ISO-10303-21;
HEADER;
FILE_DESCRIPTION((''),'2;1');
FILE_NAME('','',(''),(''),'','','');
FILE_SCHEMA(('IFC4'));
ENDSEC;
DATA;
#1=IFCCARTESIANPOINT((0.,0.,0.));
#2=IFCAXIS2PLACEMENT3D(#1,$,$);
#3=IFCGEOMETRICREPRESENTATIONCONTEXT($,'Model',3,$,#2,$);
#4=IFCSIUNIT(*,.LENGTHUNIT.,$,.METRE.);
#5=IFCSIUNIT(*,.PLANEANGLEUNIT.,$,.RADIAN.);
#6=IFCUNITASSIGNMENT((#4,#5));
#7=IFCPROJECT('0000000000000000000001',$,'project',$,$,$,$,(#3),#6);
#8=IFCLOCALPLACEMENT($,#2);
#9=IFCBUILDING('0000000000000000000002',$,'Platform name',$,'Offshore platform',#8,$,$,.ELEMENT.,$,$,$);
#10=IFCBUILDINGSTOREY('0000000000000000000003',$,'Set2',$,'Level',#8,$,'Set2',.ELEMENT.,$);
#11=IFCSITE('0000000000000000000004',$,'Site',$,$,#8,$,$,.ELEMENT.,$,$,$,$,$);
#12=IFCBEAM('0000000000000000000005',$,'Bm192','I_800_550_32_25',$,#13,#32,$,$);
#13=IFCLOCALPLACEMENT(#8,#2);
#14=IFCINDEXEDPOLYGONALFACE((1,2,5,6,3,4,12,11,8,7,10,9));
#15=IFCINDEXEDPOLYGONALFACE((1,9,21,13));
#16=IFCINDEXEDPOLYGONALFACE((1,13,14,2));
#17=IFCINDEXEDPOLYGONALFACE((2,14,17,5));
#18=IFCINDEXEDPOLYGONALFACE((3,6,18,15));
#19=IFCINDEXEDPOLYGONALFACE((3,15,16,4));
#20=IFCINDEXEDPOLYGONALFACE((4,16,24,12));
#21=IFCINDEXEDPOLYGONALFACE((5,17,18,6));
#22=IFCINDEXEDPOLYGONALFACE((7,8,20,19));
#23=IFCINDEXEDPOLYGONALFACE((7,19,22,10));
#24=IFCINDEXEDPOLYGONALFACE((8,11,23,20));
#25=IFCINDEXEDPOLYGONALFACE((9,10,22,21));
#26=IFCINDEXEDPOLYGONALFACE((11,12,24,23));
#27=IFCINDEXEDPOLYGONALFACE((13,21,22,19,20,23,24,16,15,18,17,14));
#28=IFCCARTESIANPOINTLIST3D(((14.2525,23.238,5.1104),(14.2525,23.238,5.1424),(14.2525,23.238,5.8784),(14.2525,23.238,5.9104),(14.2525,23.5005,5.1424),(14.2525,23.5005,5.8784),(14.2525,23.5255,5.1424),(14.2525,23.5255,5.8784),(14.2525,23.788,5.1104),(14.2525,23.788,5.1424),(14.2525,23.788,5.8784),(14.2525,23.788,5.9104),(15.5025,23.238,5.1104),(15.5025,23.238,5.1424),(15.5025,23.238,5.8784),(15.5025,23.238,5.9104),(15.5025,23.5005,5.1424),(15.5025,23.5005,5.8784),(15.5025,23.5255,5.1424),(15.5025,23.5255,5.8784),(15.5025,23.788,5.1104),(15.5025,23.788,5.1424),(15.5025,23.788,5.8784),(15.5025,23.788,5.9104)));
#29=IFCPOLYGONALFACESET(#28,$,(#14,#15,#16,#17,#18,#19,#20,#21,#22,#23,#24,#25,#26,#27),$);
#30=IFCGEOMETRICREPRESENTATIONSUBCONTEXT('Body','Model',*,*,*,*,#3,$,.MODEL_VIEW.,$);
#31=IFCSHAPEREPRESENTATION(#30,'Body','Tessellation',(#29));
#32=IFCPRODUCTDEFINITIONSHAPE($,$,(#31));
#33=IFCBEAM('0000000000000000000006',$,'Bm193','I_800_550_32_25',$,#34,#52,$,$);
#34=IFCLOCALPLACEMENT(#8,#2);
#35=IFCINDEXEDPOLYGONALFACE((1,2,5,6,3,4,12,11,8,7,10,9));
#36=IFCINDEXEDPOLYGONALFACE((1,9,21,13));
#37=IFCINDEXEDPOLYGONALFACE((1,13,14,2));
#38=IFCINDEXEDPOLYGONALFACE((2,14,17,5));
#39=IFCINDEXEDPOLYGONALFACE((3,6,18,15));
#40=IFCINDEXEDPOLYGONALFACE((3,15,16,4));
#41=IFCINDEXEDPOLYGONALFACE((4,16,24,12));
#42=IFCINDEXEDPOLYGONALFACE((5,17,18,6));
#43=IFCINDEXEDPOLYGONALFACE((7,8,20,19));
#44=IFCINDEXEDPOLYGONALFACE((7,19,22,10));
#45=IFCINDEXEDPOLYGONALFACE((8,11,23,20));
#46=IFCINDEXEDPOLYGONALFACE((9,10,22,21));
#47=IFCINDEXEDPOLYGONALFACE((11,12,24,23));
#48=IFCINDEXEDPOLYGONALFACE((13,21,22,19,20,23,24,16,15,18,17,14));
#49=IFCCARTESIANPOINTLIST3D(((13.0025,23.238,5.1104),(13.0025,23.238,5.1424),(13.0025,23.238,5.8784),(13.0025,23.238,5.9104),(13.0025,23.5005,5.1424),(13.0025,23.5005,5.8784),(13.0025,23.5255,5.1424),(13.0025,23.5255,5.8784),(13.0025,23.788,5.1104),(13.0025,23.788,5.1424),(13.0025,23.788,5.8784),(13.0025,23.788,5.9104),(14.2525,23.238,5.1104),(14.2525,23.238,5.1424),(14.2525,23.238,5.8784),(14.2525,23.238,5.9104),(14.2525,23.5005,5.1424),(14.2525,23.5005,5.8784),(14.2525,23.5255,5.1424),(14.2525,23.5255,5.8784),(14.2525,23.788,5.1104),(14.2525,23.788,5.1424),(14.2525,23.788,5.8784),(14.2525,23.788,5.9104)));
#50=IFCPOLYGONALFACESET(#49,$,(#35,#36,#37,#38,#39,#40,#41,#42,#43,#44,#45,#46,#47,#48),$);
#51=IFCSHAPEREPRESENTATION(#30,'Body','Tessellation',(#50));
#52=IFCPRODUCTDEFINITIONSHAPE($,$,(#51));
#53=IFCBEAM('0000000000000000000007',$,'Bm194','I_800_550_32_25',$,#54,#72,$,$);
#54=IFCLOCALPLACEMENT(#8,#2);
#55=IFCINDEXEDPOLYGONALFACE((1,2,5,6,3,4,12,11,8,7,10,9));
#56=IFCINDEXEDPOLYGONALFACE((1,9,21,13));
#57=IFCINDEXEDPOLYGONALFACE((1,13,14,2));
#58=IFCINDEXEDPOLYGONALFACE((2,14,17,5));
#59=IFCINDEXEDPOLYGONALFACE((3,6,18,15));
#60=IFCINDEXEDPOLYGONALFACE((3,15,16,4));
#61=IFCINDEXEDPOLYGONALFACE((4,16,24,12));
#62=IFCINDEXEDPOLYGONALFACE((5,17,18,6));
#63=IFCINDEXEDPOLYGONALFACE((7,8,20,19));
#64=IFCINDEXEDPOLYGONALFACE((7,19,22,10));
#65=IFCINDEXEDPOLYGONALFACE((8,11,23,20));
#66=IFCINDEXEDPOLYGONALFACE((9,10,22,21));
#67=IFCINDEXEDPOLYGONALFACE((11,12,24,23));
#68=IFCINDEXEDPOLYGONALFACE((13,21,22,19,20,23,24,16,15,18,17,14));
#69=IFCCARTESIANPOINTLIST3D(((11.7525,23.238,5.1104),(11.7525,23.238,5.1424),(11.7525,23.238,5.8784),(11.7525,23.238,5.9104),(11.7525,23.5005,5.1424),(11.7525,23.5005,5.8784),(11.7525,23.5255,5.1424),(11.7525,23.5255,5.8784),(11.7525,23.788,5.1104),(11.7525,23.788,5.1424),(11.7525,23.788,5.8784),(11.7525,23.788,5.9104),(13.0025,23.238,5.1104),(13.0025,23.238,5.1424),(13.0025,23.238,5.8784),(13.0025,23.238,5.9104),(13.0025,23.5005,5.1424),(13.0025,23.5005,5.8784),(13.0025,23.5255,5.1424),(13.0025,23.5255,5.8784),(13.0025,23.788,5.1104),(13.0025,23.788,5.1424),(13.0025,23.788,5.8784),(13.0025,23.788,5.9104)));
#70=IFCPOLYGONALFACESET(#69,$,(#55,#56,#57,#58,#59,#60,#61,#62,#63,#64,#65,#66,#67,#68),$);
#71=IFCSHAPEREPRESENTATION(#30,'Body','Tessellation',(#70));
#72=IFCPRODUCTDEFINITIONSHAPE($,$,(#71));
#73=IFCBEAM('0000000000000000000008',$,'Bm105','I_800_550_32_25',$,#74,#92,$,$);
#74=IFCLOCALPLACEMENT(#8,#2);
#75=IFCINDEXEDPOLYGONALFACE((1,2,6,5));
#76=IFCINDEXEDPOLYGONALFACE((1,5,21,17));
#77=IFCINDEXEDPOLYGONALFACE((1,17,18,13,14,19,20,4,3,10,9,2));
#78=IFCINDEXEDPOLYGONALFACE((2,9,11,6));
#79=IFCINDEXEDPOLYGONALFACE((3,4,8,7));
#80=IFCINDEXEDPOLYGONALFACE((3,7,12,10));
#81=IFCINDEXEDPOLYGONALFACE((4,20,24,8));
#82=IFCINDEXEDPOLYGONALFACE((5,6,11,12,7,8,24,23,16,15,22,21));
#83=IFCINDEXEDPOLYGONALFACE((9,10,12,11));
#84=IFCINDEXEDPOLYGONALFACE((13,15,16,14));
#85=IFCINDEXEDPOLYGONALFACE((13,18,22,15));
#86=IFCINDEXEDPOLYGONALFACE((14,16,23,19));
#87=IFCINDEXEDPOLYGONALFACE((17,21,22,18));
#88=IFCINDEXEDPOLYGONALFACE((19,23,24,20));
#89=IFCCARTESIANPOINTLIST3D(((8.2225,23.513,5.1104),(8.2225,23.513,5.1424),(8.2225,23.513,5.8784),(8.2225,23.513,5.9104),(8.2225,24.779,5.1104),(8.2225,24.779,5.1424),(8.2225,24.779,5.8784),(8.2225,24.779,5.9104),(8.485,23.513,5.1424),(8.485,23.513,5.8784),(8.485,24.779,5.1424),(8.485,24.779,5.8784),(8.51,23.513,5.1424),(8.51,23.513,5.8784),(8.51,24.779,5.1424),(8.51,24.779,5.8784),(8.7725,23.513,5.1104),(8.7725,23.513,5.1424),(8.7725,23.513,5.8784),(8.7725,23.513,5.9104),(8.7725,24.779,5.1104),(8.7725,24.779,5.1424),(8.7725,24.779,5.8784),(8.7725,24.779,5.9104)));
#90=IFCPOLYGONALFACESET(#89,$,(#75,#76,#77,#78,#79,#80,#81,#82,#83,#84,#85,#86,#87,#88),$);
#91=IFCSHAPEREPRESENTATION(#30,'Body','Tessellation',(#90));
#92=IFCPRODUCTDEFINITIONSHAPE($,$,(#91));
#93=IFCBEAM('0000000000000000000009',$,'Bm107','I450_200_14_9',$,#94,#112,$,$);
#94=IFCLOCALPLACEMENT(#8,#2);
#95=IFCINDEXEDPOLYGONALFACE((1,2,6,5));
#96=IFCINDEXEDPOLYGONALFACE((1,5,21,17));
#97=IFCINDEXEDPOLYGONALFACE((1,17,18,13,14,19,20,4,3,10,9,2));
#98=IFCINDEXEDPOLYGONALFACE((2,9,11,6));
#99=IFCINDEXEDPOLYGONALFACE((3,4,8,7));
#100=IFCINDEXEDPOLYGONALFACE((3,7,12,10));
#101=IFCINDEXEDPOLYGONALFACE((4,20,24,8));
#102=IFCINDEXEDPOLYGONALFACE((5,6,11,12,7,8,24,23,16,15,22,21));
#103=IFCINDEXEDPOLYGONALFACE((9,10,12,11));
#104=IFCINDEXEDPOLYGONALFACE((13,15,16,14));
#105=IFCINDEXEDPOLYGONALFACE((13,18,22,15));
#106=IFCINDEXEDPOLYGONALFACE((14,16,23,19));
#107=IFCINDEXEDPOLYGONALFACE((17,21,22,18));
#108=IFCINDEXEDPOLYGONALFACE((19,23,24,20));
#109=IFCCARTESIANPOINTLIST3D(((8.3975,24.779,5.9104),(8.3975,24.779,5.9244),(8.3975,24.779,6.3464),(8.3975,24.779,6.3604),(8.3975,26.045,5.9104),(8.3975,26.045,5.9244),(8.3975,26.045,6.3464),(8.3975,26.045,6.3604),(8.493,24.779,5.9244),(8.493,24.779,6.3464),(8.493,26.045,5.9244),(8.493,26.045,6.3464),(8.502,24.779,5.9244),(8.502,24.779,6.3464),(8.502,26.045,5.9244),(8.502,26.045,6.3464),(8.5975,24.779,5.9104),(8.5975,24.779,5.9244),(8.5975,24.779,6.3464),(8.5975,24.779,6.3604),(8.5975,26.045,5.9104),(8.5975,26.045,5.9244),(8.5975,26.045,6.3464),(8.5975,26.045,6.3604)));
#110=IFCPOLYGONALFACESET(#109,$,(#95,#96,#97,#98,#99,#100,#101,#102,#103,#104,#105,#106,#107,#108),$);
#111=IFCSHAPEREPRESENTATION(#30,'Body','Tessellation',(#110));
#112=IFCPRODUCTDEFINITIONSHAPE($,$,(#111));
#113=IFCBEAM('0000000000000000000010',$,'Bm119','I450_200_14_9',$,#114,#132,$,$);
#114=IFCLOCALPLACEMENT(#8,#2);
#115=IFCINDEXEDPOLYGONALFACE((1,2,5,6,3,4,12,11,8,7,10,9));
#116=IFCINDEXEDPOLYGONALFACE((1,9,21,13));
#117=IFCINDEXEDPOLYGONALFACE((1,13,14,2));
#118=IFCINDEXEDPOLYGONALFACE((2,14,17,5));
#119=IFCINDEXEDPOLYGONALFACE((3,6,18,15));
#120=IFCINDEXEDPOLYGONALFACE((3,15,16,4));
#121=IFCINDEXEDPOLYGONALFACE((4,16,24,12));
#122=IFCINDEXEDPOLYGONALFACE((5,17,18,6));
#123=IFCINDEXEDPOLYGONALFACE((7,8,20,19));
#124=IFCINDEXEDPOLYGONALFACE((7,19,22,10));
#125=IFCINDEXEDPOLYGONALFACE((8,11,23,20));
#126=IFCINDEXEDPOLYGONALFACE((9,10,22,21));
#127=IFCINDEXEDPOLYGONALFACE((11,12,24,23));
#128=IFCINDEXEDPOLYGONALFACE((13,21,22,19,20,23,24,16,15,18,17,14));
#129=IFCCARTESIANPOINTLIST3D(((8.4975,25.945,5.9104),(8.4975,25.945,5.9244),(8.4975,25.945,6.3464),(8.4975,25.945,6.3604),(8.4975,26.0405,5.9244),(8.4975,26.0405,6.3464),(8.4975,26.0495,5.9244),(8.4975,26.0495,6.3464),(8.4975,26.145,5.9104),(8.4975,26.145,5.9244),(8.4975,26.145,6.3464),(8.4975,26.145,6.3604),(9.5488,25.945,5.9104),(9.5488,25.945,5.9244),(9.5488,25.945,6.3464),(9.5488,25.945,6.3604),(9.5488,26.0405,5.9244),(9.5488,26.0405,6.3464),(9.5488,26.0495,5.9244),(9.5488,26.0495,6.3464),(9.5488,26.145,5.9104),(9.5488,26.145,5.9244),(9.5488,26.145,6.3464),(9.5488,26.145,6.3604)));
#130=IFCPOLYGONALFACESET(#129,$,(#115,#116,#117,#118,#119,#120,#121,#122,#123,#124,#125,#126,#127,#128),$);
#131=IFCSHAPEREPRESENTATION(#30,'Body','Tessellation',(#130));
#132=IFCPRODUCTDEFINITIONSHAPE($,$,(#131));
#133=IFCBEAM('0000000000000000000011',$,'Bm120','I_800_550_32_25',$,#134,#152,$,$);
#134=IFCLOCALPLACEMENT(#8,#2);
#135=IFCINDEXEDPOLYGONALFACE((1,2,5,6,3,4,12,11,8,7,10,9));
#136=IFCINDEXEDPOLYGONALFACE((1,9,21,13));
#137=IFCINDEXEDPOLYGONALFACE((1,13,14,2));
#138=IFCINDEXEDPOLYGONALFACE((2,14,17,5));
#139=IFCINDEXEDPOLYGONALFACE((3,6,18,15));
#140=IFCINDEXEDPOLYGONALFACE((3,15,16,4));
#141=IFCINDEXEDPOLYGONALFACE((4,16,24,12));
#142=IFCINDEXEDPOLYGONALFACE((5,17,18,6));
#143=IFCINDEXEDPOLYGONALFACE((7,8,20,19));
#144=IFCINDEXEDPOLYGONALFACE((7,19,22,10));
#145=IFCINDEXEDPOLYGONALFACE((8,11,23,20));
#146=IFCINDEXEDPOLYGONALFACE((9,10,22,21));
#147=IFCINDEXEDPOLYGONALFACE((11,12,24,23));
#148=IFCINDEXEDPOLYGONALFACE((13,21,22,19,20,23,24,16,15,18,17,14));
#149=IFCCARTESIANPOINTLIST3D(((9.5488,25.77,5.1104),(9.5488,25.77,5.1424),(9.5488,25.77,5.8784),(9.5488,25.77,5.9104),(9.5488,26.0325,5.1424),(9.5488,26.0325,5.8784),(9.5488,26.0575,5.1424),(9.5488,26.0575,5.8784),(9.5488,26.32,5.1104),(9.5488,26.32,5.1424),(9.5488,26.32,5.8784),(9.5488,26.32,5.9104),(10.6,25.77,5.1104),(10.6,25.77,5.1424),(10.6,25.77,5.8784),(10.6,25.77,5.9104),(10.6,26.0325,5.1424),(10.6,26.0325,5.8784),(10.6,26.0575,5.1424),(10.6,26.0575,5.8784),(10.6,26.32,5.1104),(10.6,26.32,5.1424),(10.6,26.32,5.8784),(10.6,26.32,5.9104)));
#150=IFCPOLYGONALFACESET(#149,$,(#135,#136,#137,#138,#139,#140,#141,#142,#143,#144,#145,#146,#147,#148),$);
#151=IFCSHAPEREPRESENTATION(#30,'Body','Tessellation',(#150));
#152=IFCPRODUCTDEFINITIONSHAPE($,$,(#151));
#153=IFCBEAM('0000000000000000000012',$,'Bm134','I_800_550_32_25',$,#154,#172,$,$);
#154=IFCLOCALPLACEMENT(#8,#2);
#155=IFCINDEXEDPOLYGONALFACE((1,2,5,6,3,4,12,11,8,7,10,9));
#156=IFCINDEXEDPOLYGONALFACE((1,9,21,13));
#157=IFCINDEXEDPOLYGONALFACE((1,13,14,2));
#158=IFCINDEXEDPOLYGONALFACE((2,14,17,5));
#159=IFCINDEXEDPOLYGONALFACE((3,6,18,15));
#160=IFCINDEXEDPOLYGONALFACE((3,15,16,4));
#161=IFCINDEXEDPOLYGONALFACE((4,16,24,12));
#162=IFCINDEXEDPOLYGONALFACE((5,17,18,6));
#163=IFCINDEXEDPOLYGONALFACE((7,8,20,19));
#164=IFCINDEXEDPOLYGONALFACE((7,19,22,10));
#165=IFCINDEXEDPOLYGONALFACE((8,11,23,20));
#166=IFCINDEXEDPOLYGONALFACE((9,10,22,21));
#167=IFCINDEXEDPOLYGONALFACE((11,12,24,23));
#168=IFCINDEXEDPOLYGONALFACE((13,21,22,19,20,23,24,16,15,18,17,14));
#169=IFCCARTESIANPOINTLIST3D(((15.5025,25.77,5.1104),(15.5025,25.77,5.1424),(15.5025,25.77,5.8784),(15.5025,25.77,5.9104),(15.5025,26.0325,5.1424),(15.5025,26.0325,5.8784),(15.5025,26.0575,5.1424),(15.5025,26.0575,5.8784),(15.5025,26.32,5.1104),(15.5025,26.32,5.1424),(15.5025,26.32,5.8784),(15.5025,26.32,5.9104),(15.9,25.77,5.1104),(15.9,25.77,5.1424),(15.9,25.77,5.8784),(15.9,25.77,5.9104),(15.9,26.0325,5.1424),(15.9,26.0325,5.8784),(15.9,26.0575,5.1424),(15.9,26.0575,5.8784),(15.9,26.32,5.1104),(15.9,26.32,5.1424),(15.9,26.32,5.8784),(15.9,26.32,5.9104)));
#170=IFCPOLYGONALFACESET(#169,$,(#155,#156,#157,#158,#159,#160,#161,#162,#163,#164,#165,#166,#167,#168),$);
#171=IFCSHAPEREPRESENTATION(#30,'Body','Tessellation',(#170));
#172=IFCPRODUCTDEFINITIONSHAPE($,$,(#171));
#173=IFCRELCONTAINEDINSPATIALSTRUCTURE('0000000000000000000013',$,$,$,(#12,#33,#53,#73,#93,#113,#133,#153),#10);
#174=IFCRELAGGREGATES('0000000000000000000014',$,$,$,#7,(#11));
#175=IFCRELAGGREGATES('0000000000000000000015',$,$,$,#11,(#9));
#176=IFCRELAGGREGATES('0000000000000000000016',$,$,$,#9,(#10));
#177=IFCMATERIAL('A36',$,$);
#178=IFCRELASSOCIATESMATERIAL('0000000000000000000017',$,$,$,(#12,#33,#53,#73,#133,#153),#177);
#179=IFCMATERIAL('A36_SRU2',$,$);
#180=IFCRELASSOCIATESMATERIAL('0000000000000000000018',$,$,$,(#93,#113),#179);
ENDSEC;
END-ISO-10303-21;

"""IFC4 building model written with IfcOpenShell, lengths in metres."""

from ifc_helpers import new_model, si_unit, frame, origin, origin_2d, place, context, subcontext, project, spatial, i_section, extrude, source, transform, mapped, material, element, save


model = new_model("IFC4")

# Units and contexts
model_context = context("Model", 3, world=origin())
body_context = subcontext(model_context, "Body", "Model", "MODEL_VIEW")
ifc_project = project(units=[si_unit("LENGTHUNIT", "METRE"), si_unit("PLANEANGLEUNIT", "RADIAN")], contexts=[model_context])

# Site, building, storey
placement_1 = place(None, origin())
site = spatial("IfcSite", under=ifc_project, at=placement_1, Name="Site", CompositionType="ELEMENT")
building = spatial("IfcBuilding", under=site, at=placement_1, Name="Platform name", ObjectType="Offshore platform", CompositionType="ELEMENT")
storey = spatial("IfcBuildingStorey", under=building, at=placement_1, Name="Set2", ObjectType="Level", LongName="Set2", CompositionType="ELEMENT")

# Beams
ifc_material_1 = material(Name="A36_SRU2")
ifc_material_2 = material(Name="A36")
shared_shape_1 = source(origin(), body_context, "Body", "SweptSolid", [
    extrude(i_section(OverallWidth=0.55, OverallDepth=0.8, WebThickness=0.025, FlangeThickness=0.032, FilletRadius=0.0, at=origin_2d()), frame((0.0, 0.0, 0.0), z_axis=(1.0, 0.0, 0.0), x_axis=(0.0, 1.0, 0.0)), (0.0, 0.0, 1.0), 1.25),
])
placement_2 = place(None, origin())
placement_3 = place(placement_2, origin())
placement_4 = place(placement_3, origin())
beam_1_placement = place(placement_4, frame((14.2525, 23.513, 5.5104)))
element("IfcBeam", 1, at=beam_1_placement, inside=storey, material=ifc_material_2, Name="Bm192", Description="I_800_550_32_25", context=body_context, shape_type="MappedRepresentation", body=[
    mapped(shared_shape_1, transform((0.0, 0.0, 0.0), scale=1.0)),
])
shared_shape_2 = source(origin(), body_context, "Body", "SweptSolid", [
    extrude(i_section(OverallWidth=0.55, OverallDepth=0.8, WebThickness=0.025, FlangeThickness=0.032, FilletRadius=0.0, at=origin_2d()), frame((0.0, 0.0, 0.0), z_axis=(1.0, 0.0, 0.0), x_axis=(0.0, 1.0, 0.0)), (0.0, 0.0, 1.0), 1.25),
])
placement_5 = place(None, origin())
placement_6 = place(placement_5, origin())
placement_7 = place(placement_6, origin())
beam_2_placement = place(placement_7, frame((13.0025, 23.513, 5.5104)))
element("IfcBeam", 2, at=beam_2_placement, inside=storey, material=ifc_material_2, Name="Bm193", Description="I_800_550_32_25", context=body_context, shape_type="MappedRepresentation", body=[
    mapped(shared_shape_2, transform((0.0, 0.0, 0.0), scale=1.0)),
])
shared_shape_3 = source(origin(), body_context, "Body", "SweptSolid", [
    extrude(i_section(OverallWidth=0.55, OverallDepth=0.8, WebThickness=0.025, FlangeThickness=0.032, FilletRadius=0.0, at=origin_2d()), frame((0.0, 0.0, 0.0), z_axis=(1.0, 0.0, 0.0), x_axis=(0.0, 1.0, 0.0)), (0.0, 0.0, 1.0), 1.25),
])
placement_8 = place(None, origin())
placement_9 = place(placement_8, origin())
placement_10 = place(placement_9, origin())
beam_3_placement = place(placement_10, frame((11.7525, 23.513, 5.5104)))
element("IfcBeam", 3, at=beam_3_placement, inside=storey, material=ifc_material_2, Name="Bm194", Description="I_800_550_32_25", context=body_context, shape_type="MappedRepresentation", body=[
    mapped(shared_shape_3, transform((0.0, 0.0, 0.0), scale=1.0)),
])
shared_shape_4 = source(origin(), body_context, "Body", "SweptSolid", [
    extrude(i_section(OverallWidth=0.55, OverallDepth=0.8, WebThickness=0.025, FlangeThickness=0.032, FilletRadius=0.0, at=origin_2d()), frame((0.0, 0.0, 0.0), z_axis=(0.0, -1.0, 0.0), x_axis=(1.0, 0.0, 0.0)), (0.0, 0.0, 1.0), 1.266),
])
placement_11 = place(None, origin())
placement_12 = place(placement_11, origin())
placement_13 = place(placement_12, origin())
beam_4_placement = place(placement_13, frame((8.4975, 24.779, 5.5104)))
element("IfcBeam", 4, at=beam_4_placement, inside=storey, material=ifc_material_2, Name="Bm105", Description="I_800_550_32_25", context=body_context, shape_type="MappedRepresentation", body=[
    mapped(shared_shape_4, transform((0.0, 0.0, 0.0), scale=1.0)),
])
shared_shape_5 = source(origin(), body_context, "Body", "SweptSolid", [
    extrude(i_section(OverallWidth=0.2, OverallDepth=0.45, WebThickness=0.009, FlangeThickness=0.014, FilletRadius=0.0, at=origin_2d()), frame((0.0, 0.0, 0.0), z_axis=(0.0, 1.0, 0.0), x_axis=(-1.0, 0.0, 0.0)), (0.0, 0.0, 1.0), 1.266),
])
placement_14 = place(None, origin())
placement_15 = place(placement_14, origin())
placement_16 = place(placement_15, origin())
beam_5_placement = place(placement_16, frame((8.4975, 24.779, 6.1354)))
element("IfcBeam", 5, at=beam_5_placement, inside=storey, material=ifc_material_1, Name="Bm107", Description="I450_200_14_9", context=body_context, shape_type="MappedRepresentation", body=[
    mapped(shared_shape_5, transform((0.0, 0.0, 0.0), scale=1.0)),
])
shared_shape_6 = source(origin(), body_context, "Body", "SweptSolid", [
    extrude(i_section(OverallWidth=0.2, OverallDepth=0.45, WebThickness=0.009, FlangeThickness=0.014, FilletRadius=0.0, at=origin_2d()), frame((0.0, 0.0, 0.0), z_axis=(-1.0, 0.0, 0.0), x_axis=(0.0, -1.0, 0.0)), (0.0, 0.0, 1.0), 1.0513),
])
placement_17 = place(None, origin())
placement_18 = place(placement_17, origin())
placement_19 = place(placement_18, origin())
beam_6_placement = place(placement_19, frame((9.5488, 26.045, 6.1354)))
element("IfcBeam", 6, at=beam_6_placement, inside=storey, material=ifc_material_1, Name="Bm119", Description="I450_200_14_9", context=body_context, shape_type="MappedRepresentation", body=[
    mapped(shared_shape_6, transform((0.0, 0.0, 0.0), scale=1.0)),
])
shared_shape_7 = source(origin(), body_context, "Body", "SweptSolid", [
    extrude(i_section(OverallWidth=0.55, OverallDepth=0.8, WebThickness=0.025, FlangeThickness=0.032, FilletRadius=0.0, at=origin_2d()), frame((0.0, 0.0, 0.0), z_axis=(1.0, 0.0, 0.0), x_axis=(0.0, 1.0, 0.0)), (0.0, 0.0, 1.0), 1.0513),
])
placement_20 = place(None, origin())
placement_21 = place(placement_20, origin())
placement_22 = place(placement_21, origin())
beam_7_placement = place(placement_22, frame((9.5488, 26.045, 5.5104)))
element("IfcBeam", 7, at=beam_7_placement, inside=storey, material=ifc_material_2, Name="Bm120", Description="I_800_550_32_25", context=body_context, shape_type="MappedRepresentation", body=[
    mapped(shared_shape_7, transform((0.0, 0.0, 0.0), scale=1.0)),
])
shared_shape_8 = source(origin(), body_context, "Body", "SweptSolid", [
    extrude(i_section(OverallWidth=0.55, OverallDepth=0.8, WebThickness=0.025, FlangeThickness=0.032, FilletRadius=0.0, at=origin_2d()), frame((0.0, 0.0, 0.0), z_axis=(1.0, 0.0, 0.0), x_axis=(0.0, 1.0, 0.0)), (0.0, 0.0, 1.0), 0.3975),
])
placement_23 = place(None, origin())
placement_24 = place(placement_23, origin())
placement_25 = place(placement_24, origin())
beam_8_placement = place(placement_25, frame((15.5025, 26.045, 5.5104)))
element("IfcBeam", 8, at=beam_8_placement, inside=storey, material=ifc_material_2, Name="Bm134", Description="I_800_550_32_25", context=body_context, shape_type="MappedRepresentation", body=[
    mapped(shared_shape_8, transform((0.0, 0.0, 0.0), scale=1.0)),
])

save(model, "model.ifc")
